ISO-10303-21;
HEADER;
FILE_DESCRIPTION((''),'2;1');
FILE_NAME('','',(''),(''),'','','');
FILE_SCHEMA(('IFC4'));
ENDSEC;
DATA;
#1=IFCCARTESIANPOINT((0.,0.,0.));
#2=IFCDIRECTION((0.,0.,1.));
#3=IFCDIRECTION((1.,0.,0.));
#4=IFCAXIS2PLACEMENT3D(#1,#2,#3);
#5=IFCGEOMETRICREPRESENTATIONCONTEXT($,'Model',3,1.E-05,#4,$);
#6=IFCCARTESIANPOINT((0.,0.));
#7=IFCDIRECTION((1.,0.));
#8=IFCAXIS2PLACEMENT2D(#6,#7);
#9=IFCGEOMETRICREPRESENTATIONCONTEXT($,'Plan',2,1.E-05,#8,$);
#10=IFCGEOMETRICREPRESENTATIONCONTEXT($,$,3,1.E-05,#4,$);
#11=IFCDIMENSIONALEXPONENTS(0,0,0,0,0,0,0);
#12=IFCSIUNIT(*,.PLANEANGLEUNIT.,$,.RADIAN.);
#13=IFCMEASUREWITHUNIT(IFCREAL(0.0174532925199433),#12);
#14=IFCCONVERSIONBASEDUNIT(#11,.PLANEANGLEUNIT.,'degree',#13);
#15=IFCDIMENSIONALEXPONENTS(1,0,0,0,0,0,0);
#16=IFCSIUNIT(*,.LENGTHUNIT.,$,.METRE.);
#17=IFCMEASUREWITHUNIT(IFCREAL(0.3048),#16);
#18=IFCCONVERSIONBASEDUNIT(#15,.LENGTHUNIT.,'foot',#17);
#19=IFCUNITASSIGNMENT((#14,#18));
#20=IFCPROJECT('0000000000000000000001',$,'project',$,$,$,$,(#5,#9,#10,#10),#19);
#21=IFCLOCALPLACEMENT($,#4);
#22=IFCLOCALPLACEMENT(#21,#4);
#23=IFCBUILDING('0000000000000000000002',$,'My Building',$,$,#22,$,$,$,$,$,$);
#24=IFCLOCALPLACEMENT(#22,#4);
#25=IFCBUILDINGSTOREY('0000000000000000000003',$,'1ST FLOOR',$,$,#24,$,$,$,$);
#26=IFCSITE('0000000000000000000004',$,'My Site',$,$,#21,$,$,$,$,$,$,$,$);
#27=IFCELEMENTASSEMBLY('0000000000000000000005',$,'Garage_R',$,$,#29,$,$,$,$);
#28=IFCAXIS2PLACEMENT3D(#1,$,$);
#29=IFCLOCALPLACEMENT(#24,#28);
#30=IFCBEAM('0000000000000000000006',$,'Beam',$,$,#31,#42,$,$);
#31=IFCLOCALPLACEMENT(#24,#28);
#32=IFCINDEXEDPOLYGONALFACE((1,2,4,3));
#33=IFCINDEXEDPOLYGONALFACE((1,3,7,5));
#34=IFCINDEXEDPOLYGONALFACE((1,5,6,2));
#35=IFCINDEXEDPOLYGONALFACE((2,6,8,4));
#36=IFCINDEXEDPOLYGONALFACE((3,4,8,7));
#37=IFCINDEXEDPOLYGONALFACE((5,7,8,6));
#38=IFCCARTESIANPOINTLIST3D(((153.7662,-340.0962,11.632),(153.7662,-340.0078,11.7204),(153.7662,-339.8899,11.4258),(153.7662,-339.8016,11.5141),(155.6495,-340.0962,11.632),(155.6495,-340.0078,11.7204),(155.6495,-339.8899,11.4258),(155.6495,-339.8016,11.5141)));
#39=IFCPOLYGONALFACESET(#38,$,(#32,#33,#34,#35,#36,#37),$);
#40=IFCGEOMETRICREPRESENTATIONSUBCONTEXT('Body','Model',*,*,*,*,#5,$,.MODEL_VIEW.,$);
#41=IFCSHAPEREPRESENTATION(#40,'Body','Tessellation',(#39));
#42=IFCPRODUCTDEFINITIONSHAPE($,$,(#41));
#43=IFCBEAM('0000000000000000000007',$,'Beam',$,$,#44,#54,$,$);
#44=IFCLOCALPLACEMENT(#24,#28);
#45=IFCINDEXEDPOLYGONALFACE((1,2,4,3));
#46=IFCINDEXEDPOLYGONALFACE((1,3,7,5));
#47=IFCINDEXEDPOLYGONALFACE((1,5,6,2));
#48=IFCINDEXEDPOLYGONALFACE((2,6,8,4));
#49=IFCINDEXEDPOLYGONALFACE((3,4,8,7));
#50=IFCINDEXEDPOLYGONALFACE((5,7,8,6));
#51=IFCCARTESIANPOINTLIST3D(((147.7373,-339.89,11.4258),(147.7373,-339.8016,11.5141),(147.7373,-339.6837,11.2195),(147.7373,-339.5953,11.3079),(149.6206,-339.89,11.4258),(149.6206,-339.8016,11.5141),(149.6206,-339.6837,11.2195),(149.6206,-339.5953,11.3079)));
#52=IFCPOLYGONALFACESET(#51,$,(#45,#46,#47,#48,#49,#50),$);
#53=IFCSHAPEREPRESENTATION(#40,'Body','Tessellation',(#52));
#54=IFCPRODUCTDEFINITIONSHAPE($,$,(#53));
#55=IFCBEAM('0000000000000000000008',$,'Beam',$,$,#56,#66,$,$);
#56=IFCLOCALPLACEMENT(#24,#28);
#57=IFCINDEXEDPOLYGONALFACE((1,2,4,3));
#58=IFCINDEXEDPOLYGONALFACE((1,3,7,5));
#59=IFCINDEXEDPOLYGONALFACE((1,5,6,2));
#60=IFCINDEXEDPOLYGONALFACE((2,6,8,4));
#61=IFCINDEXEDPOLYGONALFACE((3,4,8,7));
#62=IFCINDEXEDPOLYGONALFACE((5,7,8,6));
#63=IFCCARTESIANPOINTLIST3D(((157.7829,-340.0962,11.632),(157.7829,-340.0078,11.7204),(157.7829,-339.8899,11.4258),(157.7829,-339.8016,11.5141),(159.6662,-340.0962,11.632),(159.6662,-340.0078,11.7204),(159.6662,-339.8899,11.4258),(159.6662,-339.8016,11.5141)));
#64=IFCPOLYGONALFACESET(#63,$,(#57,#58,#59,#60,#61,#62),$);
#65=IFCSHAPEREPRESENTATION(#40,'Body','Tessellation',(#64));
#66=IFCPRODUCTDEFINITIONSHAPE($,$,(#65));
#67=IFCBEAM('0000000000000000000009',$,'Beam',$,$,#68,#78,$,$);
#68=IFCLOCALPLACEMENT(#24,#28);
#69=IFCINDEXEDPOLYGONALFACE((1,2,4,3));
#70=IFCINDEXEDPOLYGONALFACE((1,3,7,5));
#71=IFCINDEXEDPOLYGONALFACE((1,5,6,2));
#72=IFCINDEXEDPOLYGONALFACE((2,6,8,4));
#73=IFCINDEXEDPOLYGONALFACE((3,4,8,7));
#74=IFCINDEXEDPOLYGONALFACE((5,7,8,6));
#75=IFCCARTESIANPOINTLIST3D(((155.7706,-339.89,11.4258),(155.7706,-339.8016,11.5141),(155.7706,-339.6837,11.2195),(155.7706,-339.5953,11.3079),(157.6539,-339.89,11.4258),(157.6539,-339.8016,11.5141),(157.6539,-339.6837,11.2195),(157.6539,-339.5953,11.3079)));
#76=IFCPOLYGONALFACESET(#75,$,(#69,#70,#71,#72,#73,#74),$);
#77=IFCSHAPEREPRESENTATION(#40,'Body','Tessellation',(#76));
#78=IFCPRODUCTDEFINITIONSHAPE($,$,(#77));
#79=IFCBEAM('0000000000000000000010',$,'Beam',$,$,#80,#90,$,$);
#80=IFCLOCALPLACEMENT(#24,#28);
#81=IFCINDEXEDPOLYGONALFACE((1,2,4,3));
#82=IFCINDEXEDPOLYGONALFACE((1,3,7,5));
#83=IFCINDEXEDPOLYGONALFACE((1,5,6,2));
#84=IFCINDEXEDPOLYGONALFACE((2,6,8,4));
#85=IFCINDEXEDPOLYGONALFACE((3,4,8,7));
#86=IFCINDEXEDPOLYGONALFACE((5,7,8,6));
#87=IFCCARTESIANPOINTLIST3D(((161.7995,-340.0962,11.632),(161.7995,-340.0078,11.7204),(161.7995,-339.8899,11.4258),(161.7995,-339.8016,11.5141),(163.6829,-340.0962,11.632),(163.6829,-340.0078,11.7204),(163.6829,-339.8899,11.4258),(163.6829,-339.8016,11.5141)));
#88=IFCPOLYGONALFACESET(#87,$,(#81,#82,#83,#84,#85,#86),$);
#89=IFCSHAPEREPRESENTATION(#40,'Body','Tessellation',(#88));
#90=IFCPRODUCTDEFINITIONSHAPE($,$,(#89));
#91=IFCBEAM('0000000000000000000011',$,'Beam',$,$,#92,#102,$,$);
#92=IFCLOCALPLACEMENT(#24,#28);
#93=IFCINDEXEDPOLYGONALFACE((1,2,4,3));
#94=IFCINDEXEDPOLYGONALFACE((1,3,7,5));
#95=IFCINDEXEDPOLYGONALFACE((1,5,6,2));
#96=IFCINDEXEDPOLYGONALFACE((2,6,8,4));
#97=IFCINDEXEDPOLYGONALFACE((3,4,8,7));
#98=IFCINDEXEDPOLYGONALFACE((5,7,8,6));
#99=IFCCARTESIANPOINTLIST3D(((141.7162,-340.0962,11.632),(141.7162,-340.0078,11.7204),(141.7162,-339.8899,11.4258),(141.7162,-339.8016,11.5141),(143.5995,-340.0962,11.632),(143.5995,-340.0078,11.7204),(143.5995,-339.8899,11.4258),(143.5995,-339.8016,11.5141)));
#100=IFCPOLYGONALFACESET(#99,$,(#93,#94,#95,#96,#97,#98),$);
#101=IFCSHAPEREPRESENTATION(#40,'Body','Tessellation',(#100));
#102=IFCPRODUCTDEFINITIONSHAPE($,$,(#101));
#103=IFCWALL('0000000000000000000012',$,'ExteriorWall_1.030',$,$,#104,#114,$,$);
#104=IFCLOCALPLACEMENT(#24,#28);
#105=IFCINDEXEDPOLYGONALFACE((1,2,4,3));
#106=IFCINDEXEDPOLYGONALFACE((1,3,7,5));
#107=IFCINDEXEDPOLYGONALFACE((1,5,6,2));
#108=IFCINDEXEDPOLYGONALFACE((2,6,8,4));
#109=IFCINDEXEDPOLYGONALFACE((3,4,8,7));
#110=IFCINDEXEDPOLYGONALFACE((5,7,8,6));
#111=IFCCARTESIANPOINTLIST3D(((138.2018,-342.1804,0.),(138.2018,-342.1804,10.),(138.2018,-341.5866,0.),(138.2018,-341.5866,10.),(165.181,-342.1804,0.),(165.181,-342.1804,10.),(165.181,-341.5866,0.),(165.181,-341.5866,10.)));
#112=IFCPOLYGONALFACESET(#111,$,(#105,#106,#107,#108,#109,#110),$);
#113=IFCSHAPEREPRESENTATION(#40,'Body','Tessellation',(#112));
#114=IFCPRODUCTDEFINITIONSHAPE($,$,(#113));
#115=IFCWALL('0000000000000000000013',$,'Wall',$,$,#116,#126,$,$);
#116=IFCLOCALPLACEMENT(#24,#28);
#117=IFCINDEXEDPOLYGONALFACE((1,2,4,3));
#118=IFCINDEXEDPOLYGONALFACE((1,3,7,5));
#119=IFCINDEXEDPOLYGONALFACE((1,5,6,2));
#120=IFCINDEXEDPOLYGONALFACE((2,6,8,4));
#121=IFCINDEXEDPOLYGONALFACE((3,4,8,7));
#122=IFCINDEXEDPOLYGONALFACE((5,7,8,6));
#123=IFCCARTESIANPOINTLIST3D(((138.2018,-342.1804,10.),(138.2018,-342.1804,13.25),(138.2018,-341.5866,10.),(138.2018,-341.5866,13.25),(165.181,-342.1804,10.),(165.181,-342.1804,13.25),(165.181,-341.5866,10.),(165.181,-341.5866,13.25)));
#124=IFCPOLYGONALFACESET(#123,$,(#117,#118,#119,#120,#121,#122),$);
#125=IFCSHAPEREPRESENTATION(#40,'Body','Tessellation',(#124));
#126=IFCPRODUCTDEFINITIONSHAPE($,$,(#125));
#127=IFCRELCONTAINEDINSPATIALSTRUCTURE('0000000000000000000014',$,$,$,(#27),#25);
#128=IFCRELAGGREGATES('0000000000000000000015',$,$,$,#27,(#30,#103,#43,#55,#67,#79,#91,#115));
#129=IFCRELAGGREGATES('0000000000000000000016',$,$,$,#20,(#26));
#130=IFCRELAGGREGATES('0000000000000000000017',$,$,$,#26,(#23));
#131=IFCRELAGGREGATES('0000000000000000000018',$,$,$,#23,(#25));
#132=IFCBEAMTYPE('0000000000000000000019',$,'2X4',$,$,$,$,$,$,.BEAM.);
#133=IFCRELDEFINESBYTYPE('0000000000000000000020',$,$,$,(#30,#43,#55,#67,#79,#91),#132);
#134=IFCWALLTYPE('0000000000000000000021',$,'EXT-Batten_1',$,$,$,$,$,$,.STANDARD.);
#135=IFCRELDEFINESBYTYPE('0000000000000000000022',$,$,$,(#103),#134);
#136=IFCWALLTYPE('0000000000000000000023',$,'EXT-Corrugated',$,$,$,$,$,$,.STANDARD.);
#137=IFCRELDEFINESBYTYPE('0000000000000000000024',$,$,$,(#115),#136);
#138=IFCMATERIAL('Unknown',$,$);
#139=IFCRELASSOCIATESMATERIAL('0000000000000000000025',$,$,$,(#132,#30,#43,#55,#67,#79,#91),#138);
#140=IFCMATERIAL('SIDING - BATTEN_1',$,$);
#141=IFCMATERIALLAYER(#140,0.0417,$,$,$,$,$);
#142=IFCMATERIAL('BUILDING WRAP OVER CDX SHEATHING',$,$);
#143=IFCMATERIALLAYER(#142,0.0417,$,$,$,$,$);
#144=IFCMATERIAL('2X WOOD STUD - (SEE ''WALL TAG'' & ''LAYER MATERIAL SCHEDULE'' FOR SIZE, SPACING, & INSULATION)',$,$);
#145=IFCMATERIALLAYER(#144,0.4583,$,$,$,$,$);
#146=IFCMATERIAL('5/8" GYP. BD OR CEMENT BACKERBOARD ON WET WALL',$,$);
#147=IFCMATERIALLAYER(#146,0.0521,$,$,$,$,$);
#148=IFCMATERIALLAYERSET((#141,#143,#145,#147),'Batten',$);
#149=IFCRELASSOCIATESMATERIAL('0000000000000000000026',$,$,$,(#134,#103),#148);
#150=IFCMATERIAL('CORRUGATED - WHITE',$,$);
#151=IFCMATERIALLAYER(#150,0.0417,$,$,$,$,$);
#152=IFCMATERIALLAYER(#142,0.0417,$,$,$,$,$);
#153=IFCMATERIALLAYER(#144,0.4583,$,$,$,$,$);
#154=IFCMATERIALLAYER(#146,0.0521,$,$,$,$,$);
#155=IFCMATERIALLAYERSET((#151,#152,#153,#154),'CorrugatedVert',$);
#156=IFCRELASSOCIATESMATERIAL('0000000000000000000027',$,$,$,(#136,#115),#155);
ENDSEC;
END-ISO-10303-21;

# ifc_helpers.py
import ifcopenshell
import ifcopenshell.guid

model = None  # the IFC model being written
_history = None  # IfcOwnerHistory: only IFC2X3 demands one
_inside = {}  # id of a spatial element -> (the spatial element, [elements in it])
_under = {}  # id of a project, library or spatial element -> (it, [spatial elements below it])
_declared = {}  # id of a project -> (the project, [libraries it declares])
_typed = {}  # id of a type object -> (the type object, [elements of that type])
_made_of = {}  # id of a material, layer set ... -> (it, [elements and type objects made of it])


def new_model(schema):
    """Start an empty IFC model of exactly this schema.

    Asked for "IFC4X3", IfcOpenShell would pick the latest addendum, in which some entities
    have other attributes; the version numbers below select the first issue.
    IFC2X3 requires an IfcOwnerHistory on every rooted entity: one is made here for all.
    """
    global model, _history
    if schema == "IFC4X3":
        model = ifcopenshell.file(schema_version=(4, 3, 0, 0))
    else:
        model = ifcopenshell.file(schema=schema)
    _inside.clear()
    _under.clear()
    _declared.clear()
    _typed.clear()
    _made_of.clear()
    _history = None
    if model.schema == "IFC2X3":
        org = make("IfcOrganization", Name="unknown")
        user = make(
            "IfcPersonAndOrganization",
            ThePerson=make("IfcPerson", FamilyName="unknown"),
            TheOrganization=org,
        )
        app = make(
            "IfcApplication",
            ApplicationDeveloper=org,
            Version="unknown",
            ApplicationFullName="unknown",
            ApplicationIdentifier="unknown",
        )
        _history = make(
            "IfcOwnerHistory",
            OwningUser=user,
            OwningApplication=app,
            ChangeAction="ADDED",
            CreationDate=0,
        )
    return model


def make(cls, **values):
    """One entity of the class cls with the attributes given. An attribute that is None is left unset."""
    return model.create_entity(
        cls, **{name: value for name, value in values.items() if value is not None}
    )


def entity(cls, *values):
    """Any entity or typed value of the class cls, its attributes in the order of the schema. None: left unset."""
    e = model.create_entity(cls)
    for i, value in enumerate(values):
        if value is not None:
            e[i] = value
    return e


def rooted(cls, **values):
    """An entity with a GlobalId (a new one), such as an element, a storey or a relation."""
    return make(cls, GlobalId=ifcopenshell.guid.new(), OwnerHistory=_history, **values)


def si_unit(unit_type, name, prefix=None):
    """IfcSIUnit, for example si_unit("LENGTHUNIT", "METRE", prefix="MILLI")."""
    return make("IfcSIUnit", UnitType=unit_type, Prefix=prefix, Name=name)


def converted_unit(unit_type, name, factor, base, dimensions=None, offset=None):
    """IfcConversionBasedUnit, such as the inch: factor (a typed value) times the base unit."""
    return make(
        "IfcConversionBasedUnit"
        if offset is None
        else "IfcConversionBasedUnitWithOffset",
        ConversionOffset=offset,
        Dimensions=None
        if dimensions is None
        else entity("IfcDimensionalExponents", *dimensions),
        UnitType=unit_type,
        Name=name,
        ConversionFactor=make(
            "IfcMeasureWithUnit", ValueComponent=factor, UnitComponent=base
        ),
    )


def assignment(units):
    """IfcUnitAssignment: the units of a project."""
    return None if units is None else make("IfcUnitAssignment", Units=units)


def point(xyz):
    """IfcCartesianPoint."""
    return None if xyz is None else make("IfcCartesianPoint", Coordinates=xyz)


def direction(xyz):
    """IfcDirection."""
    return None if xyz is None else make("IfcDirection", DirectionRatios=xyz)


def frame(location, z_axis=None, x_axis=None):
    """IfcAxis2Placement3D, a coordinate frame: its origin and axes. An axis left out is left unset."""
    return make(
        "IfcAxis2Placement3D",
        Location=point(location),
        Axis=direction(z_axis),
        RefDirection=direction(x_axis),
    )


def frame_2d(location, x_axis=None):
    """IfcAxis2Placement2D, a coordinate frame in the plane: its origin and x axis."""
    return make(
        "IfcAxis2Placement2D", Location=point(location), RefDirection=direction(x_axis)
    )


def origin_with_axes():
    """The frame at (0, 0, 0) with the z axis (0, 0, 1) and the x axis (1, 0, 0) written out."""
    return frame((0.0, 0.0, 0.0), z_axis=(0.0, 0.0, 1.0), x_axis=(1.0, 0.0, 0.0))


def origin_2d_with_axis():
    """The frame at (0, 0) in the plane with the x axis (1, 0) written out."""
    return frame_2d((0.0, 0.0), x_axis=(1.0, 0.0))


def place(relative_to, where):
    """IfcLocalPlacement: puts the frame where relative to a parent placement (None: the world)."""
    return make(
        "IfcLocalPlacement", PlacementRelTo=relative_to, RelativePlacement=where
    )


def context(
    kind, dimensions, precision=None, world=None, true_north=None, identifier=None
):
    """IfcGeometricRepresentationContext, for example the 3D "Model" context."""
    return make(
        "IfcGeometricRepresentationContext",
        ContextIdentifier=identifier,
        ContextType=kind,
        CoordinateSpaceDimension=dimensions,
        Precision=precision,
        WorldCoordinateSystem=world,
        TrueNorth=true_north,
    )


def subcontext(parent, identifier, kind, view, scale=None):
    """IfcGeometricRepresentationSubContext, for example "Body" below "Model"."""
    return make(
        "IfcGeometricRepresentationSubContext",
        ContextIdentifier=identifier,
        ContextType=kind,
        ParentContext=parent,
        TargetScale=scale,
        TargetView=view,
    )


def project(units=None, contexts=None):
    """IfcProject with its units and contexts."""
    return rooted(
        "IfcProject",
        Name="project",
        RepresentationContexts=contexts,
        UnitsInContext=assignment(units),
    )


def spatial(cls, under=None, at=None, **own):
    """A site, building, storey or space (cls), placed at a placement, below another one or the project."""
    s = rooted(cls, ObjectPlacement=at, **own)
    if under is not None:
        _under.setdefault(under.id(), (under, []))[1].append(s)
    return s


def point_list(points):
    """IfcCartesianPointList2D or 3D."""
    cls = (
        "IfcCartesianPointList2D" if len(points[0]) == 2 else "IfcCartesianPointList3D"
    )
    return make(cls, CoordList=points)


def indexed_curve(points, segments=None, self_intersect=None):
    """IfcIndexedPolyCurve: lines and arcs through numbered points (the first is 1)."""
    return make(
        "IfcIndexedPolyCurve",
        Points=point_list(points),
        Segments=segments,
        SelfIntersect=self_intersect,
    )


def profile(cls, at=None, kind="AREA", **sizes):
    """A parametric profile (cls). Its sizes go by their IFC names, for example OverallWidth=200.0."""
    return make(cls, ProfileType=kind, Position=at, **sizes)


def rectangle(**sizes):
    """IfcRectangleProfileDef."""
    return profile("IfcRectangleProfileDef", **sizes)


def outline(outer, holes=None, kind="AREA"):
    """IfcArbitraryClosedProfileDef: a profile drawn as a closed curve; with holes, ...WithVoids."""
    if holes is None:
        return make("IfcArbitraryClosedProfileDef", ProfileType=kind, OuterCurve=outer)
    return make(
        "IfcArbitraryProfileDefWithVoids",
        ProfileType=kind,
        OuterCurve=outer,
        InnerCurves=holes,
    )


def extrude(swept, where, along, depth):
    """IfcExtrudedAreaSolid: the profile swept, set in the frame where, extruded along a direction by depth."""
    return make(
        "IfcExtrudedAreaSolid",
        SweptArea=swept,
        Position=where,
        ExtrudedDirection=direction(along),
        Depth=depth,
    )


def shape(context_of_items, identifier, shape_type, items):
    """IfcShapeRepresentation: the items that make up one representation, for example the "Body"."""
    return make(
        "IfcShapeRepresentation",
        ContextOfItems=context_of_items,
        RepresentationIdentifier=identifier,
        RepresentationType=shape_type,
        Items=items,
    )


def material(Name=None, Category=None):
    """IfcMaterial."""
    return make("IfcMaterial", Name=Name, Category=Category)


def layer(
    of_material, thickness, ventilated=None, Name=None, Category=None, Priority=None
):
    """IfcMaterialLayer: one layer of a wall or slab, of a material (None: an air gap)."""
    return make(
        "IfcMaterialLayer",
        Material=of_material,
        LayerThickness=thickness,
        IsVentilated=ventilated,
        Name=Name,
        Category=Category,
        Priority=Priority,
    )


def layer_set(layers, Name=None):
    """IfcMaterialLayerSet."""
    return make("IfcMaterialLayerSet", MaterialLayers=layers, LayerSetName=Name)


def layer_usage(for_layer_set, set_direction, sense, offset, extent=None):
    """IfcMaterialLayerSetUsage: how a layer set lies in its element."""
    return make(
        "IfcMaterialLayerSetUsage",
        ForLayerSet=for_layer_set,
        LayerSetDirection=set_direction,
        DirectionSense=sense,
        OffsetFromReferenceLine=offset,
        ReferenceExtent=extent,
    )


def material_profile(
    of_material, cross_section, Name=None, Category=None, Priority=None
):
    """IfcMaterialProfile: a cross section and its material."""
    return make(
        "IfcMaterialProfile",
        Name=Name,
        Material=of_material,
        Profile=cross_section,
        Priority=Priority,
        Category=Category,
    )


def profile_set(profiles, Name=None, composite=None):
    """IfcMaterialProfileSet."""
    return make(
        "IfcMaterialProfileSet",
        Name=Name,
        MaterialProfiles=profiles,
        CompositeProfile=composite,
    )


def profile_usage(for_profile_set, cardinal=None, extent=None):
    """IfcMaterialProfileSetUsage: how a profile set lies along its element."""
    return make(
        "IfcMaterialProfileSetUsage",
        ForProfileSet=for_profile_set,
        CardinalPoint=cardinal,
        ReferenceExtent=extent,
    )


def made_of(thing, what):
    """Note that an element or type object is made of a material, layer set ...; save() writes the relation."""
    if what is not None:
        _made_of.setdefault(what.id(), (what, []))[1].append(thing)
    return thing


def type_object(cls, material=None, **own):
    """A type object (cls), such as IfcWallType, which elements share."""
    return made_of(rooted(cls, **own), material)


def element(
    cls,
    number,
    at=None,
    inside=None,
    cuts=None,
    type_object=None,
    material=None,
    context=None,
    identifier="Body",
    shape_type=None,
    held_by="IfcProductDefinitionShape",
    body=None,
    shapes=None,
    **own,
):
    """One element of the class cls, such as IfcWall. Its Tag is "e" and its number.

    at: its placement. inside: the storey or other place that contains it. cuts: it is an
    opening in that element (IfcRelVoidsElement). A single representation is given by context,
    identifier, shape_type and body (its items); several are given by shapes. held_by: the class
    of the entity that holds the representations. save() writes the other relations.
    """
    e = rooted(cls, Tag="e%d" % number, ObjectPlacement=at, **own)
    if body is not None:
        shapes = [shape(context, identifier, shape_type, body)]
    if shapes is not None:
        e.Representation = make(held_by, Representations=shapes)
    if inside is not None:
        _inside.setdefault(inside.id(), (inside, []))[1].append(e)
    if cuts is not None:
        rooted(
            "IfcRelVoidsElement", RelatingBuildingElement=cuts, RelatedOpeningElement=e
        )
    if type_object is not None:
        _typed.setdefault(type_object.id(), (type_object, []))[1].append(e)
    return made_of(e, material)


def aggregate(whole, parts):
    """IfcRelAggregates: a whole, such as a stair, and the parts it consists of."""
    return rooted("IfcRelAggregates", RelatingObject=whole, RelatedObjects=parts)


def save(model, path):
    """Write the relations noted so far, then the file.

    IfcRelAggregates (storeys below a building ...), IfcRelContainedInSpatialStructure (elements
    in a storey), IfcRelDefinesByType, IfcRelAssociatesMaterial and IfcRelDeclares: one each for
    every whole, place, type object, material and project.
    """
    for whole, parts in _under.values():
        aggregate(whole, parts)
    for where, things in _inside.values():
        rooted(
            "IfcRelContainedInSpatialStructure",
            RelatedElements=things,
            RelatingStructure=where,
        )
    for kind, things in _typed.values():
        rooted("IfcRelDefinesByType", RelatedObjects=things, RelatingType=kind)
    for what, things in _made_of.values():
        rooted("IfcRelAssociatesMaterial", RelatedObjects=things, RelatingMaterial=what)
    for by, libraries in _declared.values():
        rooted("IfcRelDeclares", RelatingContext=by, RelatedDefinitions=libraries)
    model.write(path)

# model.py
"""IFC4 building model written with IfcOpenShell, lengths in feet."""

from ifc_helpers import new_model, entity, si_unit, converted_unit, frame, origin_with_axes, origin_2d_with_axis, place, context, subcontext, project, spatial, indexed_curve, rectangle, outline, extrude, material, layer, layer_set, layer_usage, material_profile, profile_set, profile_usage, type_object, element, aggregate, save


model = new_model("IFC4")

# Units and contexts
model_context = context("Model", 3, precision=1e-05, world=origin_with_axes())
plan_context = context("Plan", 2, precision=1e-05, world=origin_2d_with_axis())
context_of_model = context(None, 3, precision=1e-05, world=origin_with_axes())
body_context = subcontext(model_context, "Body", "Model", "MODEL_VIEW")
ifc_project = project(units=[converted_unit("PLANEANGLEUNIT", "degree", entity("IfcReal", 0.0174532925199433), si_unit("PLANEANGLEUNIT", "RADIAN"), dimensions=[0, 0, 0, 0, 0, 0, 0]), converted_unit("LENGTHUNIT", "foot", entity("IfcReal", 0.3048), si_unit("LENGTHUNIT", "METRE"), dimensions=[1, 0, 0, 0, 0, 0, 0])], contexts=[model_context, plan_context, context_of_model, context_of_model])

# Site, building, storey
site_placement = place(None, origin_with_axes())
site = spatial("IfcSite", under=ifc_project, at=site_placement, Name="My Site")
building_placement = place(site_placement, origin_with_axes())
building = spatial("IfcBuilding", under=site, at=building_placement, Name="My Building")
storey_placement = place(building_placement, origin_with_axes())
storey = spatial("IfcBuildingStorey", under=building, at=storey_placement, Name="1ST FLOOR")

# Element assembly, beams
assembly_1_placement = place(storey_placement, origin_with_axes())
assembly_1 = element("IfcElementAssembly", 1, at=assembly_1_placement, inside=storey, Name="Garage_R")
ifc_material_1 = material(Name="Unknown")
ifc_material_profile_1 = material_profile(ifc_material_1, rectangle(XDim=0.125, YDim=0.2917))
ifc_profile_set_1 = profile_set([ifc_material_profile_1])
beam_type_1 = type_object("IfcBeamType", Name="2X4", PredefinedType="BEAM", material=ifc_profile_set_1)
ifc_profile_usage_1 = profile_usage(ifc_profile_set_1, cardinal=5)
beam_1_placement = place(assembly_1_placement, frame((153.7662, -339.9489, 11.5731), z_axis=(1.0, 0.0, 0.0), x_axis=(0.0, -0.707107, -0.707107)))
beam_1 = element("IfcBeam", 2, at=beam_1_placement, type_object=beam_type_1, material=ifc_profile_usage_1, Name="Beam", context=body_context, shape_type="SweptSolid", body=[
    extrude(rectangle(XDim=0.125, YDim=0.2917), origin_with_axes(), (0.0, 0.0, 1.0), 1.8833),
])
ifc_profile_usage_2 = profile_usage(ifc_profile_set_1, cardinal=5)
beam_2_placement = place(assembly_1_placement, frame((147.7373, -339.7426, 11.3668), z_axis=(1.0, 0.0, 0.0), x_axis=(0.0, -0.707107, -0.707107)))
beam_2 = element("IfcBeam", 3, at=beam_2_placement, type_object=beam_type_1, material=ifc_profile_usage_2, Name="Beam", context=body_context, shape_type="SweptSolid", body=[
    extrude(rectangle(XDim=0.125, YDim=0.2917), origin_with_axes(), (0.0, 0.0, 1.0), 1.8833),
])
ifc_profile_usage_3 = profile_usage(ifc_profile_set_1, cardinal=5)
beam_3_placement = place(assembly_1_placement, frame((157.7829, -339.9489, 11.5731), z_axis=(1.0, 0.0, 0.0), x_axis=(0.0, -0.707107, -0.707107)))
beam_3 = element("IfcBeam", 4, at=beam_3_placement, type_object=beam_type_1, material=ifc_profile_usage_3, Name="Beam", context=body_context, shape_type="SweptSolid", body=[
    extrude(rectangle(XDim=0.125, YDim=0.2917), origin_with_axes(), (0.0, 0.0, 1.0), 1.8833),
])
ifc_profile_usage_4 = profile_usage(ifc_profile_set_1, cardinal=5)
beam_4_placement = place(assembly_1_placement, frame((155.7706, -339.7426, 11.3668), z_axis=(1.0, 0.0, 0.0), x_axis=(0.0, -0.707107, -0.707107)))
beam_4 = element("IfcBeam", 5, at=beam_4_placement, type_object=beam_type_1, material=ifc_profile_usage_4, Name="Beam", context=body_context, shape_type="SweptSolid", body=[
    extrude(rectangle(XDim=0.125, YDim=0.2917), origin_with_axes(), (0.0, 0.0, 1.0), 1.8833),
])
ifc_profile_usage_5 = profile_usage(ifc_profile_set_1, cardinal=5)
beam_5_placement = place(assembly_1_placement, frame((161.7995, -339.9489, 11.5731), z_axis=(1.0, 0.0, 0.0), x_axis=(0.0, -0.707107, -0.707107)))
beam_5 = element("IfcBeam", 6, at=beam_5_placement, type_object=beam_type_1, material=ifc_profile_usage_5, Name="Beam", context=body_context, shape_type="SweptSolid", body=[
    extrude(rectangle(XDim=0.125, YDim=0.2917), origin_with_axes(), (0.0, 0.0, 1.0), 1.8833),
])
ifc_profile_usage_6 = profile_usage(ifc_profile_set_1, cardinal=5)
beam_6_placement = place(assembly_1_placement, frame((141.7162, -339.9489, 11.5731), z_axis=(1.0, 0.0, 0.0), x_axis=(0.0, -0.707107, -0.707107)))
beam_6 = element("IfcBeam", 7, at=beam_6_placement, type_object=beam_type_1, material=ifc_profile_usage_6, Name="Beam", context=body_context, shape_type="SweptSolid", body=[
    extrude(rectangle(XDim=0.125, YDim=0.2917), origin_with_axes(), (0.0, 0.0, 1.0), 1.8833),
])

# Walls
ifc_material_2 = material(Name="SIDING - BATTEN_1")
ifc_layer_1 = layer(ifc_material_2, 0.0417)
ifc_material_3 = material(Name="BUILDING WRAP OVER CDX SHEATHING")
ifc_layer_2 = layer(ifc_material_3, 0.0417)
ifc_material_4 = material(Name="2X WOOD STUD - (SEE 'WALL TAG' & 'LAYER MATERIAL SCHEDULE' FOR SIZE, SPACING, & INSULATION)")
ifc_layer_3 = layer(ifc_material_4, 0.4583)
ifc_material_5 = material(Name="5/8\" GYP. BD OR CEMENT BACKERBOARD ON WET WALL")
ifc_layer_4 = layer(ifc_material_5, 0.0521)
ifc_layer_set_1 = layer_set([ifc_layer_1, ifc_layer_2, ifc_layer_3, ifc_layer_4], Name="Batten")
ifc_layer_usage_1 = layer_usage(ifc_layer_set_1, "AXIS2", "POSITIVE", 0.0)
wall_type_1 = type_object("IfcWallType", Name="EXT-Batten_1", PredefinedType="STANDARD", material=ifc_layer_set_1)
wall_1_placement = place(assembly_1_placement, frame((165.181, -341.5866, 0.0), z_axis=(0.0, 0.0, 1.0), x_axis=(-1.0, 0.0, 0.0)))
wall_1 = element("IfcWall", 8, at=wall_1_placement, type_object=wall_type_1, material=ifc_layer_usage_1, Name="ExteriorWall_1.030", context=body_context, shape_type="SweptSolid", body=[
    extrude(outline(indexed_curve([(0.0, 0.0), (0.0, 0.5938), (26.9792, 0.5938), (26.9792, 0.0), (0.0, 0.0)], self_intersect=False)), origin_with_axes(), (0.0, 0.0, 1.0), 10.0),
])
ifc_material_6 = material(Name="CORRUGATED - WHITE")
ifc_layer_5 = layer(ifc_material_6, 0.0417)
ifc_layer_6 = layer(ifc_material_3, 0.0417)
ifc_layer_7 = layer(ifc_material_4, 0.4583)
ifc_layer_8 = layer(ifc_material_5, 0.0521)
ifc_layer_set_2 = layer_set([ifc_layer_5, ifc_layer_6, ifc_layer_7, ifc_layer_8], Name="CorrugatedVert")
ifc_layer_usage_2 = layer_usage(ifc_layer_set_2, "AXIS2", "POSITIVE", 0.0)
wall_type_2 = type_object("IfcWallType", Name="EXT-Corrugated", PredefinedType="STANDARD", material=ifc_layer_set_2)
wall_2_placement = place(assembly_1_placement, frame((165.181, -341.5866, 10.0), z_axis=(0.0, 0.0, 1.0), x_axis=(-1.0, 0.0, 0.0)))
wall_2 = element("IfcWall", 9, at=wall_2_placement, type_object=wall_type_2, material=ifc_layer_usage_2, Name="Wall", context=body_context, shape_type="SweptSolid", body=[
    extrude(outline(indexed_curve([(0.0, 0.0), (0.0, 0.5938), (26.9792, 0.5938), (26.9792, 0.0), (0.0, 0.0)], self_intersect=False)), origin_with_axes(), (0.0, 0.0, 1.0), 3.25),
])

aggregate(assembly_1, [beam_1, wall_1, beam_2, beam_3, beam_4, beam_5, beam_6, wall_2])

save(model, "model.ifc")
